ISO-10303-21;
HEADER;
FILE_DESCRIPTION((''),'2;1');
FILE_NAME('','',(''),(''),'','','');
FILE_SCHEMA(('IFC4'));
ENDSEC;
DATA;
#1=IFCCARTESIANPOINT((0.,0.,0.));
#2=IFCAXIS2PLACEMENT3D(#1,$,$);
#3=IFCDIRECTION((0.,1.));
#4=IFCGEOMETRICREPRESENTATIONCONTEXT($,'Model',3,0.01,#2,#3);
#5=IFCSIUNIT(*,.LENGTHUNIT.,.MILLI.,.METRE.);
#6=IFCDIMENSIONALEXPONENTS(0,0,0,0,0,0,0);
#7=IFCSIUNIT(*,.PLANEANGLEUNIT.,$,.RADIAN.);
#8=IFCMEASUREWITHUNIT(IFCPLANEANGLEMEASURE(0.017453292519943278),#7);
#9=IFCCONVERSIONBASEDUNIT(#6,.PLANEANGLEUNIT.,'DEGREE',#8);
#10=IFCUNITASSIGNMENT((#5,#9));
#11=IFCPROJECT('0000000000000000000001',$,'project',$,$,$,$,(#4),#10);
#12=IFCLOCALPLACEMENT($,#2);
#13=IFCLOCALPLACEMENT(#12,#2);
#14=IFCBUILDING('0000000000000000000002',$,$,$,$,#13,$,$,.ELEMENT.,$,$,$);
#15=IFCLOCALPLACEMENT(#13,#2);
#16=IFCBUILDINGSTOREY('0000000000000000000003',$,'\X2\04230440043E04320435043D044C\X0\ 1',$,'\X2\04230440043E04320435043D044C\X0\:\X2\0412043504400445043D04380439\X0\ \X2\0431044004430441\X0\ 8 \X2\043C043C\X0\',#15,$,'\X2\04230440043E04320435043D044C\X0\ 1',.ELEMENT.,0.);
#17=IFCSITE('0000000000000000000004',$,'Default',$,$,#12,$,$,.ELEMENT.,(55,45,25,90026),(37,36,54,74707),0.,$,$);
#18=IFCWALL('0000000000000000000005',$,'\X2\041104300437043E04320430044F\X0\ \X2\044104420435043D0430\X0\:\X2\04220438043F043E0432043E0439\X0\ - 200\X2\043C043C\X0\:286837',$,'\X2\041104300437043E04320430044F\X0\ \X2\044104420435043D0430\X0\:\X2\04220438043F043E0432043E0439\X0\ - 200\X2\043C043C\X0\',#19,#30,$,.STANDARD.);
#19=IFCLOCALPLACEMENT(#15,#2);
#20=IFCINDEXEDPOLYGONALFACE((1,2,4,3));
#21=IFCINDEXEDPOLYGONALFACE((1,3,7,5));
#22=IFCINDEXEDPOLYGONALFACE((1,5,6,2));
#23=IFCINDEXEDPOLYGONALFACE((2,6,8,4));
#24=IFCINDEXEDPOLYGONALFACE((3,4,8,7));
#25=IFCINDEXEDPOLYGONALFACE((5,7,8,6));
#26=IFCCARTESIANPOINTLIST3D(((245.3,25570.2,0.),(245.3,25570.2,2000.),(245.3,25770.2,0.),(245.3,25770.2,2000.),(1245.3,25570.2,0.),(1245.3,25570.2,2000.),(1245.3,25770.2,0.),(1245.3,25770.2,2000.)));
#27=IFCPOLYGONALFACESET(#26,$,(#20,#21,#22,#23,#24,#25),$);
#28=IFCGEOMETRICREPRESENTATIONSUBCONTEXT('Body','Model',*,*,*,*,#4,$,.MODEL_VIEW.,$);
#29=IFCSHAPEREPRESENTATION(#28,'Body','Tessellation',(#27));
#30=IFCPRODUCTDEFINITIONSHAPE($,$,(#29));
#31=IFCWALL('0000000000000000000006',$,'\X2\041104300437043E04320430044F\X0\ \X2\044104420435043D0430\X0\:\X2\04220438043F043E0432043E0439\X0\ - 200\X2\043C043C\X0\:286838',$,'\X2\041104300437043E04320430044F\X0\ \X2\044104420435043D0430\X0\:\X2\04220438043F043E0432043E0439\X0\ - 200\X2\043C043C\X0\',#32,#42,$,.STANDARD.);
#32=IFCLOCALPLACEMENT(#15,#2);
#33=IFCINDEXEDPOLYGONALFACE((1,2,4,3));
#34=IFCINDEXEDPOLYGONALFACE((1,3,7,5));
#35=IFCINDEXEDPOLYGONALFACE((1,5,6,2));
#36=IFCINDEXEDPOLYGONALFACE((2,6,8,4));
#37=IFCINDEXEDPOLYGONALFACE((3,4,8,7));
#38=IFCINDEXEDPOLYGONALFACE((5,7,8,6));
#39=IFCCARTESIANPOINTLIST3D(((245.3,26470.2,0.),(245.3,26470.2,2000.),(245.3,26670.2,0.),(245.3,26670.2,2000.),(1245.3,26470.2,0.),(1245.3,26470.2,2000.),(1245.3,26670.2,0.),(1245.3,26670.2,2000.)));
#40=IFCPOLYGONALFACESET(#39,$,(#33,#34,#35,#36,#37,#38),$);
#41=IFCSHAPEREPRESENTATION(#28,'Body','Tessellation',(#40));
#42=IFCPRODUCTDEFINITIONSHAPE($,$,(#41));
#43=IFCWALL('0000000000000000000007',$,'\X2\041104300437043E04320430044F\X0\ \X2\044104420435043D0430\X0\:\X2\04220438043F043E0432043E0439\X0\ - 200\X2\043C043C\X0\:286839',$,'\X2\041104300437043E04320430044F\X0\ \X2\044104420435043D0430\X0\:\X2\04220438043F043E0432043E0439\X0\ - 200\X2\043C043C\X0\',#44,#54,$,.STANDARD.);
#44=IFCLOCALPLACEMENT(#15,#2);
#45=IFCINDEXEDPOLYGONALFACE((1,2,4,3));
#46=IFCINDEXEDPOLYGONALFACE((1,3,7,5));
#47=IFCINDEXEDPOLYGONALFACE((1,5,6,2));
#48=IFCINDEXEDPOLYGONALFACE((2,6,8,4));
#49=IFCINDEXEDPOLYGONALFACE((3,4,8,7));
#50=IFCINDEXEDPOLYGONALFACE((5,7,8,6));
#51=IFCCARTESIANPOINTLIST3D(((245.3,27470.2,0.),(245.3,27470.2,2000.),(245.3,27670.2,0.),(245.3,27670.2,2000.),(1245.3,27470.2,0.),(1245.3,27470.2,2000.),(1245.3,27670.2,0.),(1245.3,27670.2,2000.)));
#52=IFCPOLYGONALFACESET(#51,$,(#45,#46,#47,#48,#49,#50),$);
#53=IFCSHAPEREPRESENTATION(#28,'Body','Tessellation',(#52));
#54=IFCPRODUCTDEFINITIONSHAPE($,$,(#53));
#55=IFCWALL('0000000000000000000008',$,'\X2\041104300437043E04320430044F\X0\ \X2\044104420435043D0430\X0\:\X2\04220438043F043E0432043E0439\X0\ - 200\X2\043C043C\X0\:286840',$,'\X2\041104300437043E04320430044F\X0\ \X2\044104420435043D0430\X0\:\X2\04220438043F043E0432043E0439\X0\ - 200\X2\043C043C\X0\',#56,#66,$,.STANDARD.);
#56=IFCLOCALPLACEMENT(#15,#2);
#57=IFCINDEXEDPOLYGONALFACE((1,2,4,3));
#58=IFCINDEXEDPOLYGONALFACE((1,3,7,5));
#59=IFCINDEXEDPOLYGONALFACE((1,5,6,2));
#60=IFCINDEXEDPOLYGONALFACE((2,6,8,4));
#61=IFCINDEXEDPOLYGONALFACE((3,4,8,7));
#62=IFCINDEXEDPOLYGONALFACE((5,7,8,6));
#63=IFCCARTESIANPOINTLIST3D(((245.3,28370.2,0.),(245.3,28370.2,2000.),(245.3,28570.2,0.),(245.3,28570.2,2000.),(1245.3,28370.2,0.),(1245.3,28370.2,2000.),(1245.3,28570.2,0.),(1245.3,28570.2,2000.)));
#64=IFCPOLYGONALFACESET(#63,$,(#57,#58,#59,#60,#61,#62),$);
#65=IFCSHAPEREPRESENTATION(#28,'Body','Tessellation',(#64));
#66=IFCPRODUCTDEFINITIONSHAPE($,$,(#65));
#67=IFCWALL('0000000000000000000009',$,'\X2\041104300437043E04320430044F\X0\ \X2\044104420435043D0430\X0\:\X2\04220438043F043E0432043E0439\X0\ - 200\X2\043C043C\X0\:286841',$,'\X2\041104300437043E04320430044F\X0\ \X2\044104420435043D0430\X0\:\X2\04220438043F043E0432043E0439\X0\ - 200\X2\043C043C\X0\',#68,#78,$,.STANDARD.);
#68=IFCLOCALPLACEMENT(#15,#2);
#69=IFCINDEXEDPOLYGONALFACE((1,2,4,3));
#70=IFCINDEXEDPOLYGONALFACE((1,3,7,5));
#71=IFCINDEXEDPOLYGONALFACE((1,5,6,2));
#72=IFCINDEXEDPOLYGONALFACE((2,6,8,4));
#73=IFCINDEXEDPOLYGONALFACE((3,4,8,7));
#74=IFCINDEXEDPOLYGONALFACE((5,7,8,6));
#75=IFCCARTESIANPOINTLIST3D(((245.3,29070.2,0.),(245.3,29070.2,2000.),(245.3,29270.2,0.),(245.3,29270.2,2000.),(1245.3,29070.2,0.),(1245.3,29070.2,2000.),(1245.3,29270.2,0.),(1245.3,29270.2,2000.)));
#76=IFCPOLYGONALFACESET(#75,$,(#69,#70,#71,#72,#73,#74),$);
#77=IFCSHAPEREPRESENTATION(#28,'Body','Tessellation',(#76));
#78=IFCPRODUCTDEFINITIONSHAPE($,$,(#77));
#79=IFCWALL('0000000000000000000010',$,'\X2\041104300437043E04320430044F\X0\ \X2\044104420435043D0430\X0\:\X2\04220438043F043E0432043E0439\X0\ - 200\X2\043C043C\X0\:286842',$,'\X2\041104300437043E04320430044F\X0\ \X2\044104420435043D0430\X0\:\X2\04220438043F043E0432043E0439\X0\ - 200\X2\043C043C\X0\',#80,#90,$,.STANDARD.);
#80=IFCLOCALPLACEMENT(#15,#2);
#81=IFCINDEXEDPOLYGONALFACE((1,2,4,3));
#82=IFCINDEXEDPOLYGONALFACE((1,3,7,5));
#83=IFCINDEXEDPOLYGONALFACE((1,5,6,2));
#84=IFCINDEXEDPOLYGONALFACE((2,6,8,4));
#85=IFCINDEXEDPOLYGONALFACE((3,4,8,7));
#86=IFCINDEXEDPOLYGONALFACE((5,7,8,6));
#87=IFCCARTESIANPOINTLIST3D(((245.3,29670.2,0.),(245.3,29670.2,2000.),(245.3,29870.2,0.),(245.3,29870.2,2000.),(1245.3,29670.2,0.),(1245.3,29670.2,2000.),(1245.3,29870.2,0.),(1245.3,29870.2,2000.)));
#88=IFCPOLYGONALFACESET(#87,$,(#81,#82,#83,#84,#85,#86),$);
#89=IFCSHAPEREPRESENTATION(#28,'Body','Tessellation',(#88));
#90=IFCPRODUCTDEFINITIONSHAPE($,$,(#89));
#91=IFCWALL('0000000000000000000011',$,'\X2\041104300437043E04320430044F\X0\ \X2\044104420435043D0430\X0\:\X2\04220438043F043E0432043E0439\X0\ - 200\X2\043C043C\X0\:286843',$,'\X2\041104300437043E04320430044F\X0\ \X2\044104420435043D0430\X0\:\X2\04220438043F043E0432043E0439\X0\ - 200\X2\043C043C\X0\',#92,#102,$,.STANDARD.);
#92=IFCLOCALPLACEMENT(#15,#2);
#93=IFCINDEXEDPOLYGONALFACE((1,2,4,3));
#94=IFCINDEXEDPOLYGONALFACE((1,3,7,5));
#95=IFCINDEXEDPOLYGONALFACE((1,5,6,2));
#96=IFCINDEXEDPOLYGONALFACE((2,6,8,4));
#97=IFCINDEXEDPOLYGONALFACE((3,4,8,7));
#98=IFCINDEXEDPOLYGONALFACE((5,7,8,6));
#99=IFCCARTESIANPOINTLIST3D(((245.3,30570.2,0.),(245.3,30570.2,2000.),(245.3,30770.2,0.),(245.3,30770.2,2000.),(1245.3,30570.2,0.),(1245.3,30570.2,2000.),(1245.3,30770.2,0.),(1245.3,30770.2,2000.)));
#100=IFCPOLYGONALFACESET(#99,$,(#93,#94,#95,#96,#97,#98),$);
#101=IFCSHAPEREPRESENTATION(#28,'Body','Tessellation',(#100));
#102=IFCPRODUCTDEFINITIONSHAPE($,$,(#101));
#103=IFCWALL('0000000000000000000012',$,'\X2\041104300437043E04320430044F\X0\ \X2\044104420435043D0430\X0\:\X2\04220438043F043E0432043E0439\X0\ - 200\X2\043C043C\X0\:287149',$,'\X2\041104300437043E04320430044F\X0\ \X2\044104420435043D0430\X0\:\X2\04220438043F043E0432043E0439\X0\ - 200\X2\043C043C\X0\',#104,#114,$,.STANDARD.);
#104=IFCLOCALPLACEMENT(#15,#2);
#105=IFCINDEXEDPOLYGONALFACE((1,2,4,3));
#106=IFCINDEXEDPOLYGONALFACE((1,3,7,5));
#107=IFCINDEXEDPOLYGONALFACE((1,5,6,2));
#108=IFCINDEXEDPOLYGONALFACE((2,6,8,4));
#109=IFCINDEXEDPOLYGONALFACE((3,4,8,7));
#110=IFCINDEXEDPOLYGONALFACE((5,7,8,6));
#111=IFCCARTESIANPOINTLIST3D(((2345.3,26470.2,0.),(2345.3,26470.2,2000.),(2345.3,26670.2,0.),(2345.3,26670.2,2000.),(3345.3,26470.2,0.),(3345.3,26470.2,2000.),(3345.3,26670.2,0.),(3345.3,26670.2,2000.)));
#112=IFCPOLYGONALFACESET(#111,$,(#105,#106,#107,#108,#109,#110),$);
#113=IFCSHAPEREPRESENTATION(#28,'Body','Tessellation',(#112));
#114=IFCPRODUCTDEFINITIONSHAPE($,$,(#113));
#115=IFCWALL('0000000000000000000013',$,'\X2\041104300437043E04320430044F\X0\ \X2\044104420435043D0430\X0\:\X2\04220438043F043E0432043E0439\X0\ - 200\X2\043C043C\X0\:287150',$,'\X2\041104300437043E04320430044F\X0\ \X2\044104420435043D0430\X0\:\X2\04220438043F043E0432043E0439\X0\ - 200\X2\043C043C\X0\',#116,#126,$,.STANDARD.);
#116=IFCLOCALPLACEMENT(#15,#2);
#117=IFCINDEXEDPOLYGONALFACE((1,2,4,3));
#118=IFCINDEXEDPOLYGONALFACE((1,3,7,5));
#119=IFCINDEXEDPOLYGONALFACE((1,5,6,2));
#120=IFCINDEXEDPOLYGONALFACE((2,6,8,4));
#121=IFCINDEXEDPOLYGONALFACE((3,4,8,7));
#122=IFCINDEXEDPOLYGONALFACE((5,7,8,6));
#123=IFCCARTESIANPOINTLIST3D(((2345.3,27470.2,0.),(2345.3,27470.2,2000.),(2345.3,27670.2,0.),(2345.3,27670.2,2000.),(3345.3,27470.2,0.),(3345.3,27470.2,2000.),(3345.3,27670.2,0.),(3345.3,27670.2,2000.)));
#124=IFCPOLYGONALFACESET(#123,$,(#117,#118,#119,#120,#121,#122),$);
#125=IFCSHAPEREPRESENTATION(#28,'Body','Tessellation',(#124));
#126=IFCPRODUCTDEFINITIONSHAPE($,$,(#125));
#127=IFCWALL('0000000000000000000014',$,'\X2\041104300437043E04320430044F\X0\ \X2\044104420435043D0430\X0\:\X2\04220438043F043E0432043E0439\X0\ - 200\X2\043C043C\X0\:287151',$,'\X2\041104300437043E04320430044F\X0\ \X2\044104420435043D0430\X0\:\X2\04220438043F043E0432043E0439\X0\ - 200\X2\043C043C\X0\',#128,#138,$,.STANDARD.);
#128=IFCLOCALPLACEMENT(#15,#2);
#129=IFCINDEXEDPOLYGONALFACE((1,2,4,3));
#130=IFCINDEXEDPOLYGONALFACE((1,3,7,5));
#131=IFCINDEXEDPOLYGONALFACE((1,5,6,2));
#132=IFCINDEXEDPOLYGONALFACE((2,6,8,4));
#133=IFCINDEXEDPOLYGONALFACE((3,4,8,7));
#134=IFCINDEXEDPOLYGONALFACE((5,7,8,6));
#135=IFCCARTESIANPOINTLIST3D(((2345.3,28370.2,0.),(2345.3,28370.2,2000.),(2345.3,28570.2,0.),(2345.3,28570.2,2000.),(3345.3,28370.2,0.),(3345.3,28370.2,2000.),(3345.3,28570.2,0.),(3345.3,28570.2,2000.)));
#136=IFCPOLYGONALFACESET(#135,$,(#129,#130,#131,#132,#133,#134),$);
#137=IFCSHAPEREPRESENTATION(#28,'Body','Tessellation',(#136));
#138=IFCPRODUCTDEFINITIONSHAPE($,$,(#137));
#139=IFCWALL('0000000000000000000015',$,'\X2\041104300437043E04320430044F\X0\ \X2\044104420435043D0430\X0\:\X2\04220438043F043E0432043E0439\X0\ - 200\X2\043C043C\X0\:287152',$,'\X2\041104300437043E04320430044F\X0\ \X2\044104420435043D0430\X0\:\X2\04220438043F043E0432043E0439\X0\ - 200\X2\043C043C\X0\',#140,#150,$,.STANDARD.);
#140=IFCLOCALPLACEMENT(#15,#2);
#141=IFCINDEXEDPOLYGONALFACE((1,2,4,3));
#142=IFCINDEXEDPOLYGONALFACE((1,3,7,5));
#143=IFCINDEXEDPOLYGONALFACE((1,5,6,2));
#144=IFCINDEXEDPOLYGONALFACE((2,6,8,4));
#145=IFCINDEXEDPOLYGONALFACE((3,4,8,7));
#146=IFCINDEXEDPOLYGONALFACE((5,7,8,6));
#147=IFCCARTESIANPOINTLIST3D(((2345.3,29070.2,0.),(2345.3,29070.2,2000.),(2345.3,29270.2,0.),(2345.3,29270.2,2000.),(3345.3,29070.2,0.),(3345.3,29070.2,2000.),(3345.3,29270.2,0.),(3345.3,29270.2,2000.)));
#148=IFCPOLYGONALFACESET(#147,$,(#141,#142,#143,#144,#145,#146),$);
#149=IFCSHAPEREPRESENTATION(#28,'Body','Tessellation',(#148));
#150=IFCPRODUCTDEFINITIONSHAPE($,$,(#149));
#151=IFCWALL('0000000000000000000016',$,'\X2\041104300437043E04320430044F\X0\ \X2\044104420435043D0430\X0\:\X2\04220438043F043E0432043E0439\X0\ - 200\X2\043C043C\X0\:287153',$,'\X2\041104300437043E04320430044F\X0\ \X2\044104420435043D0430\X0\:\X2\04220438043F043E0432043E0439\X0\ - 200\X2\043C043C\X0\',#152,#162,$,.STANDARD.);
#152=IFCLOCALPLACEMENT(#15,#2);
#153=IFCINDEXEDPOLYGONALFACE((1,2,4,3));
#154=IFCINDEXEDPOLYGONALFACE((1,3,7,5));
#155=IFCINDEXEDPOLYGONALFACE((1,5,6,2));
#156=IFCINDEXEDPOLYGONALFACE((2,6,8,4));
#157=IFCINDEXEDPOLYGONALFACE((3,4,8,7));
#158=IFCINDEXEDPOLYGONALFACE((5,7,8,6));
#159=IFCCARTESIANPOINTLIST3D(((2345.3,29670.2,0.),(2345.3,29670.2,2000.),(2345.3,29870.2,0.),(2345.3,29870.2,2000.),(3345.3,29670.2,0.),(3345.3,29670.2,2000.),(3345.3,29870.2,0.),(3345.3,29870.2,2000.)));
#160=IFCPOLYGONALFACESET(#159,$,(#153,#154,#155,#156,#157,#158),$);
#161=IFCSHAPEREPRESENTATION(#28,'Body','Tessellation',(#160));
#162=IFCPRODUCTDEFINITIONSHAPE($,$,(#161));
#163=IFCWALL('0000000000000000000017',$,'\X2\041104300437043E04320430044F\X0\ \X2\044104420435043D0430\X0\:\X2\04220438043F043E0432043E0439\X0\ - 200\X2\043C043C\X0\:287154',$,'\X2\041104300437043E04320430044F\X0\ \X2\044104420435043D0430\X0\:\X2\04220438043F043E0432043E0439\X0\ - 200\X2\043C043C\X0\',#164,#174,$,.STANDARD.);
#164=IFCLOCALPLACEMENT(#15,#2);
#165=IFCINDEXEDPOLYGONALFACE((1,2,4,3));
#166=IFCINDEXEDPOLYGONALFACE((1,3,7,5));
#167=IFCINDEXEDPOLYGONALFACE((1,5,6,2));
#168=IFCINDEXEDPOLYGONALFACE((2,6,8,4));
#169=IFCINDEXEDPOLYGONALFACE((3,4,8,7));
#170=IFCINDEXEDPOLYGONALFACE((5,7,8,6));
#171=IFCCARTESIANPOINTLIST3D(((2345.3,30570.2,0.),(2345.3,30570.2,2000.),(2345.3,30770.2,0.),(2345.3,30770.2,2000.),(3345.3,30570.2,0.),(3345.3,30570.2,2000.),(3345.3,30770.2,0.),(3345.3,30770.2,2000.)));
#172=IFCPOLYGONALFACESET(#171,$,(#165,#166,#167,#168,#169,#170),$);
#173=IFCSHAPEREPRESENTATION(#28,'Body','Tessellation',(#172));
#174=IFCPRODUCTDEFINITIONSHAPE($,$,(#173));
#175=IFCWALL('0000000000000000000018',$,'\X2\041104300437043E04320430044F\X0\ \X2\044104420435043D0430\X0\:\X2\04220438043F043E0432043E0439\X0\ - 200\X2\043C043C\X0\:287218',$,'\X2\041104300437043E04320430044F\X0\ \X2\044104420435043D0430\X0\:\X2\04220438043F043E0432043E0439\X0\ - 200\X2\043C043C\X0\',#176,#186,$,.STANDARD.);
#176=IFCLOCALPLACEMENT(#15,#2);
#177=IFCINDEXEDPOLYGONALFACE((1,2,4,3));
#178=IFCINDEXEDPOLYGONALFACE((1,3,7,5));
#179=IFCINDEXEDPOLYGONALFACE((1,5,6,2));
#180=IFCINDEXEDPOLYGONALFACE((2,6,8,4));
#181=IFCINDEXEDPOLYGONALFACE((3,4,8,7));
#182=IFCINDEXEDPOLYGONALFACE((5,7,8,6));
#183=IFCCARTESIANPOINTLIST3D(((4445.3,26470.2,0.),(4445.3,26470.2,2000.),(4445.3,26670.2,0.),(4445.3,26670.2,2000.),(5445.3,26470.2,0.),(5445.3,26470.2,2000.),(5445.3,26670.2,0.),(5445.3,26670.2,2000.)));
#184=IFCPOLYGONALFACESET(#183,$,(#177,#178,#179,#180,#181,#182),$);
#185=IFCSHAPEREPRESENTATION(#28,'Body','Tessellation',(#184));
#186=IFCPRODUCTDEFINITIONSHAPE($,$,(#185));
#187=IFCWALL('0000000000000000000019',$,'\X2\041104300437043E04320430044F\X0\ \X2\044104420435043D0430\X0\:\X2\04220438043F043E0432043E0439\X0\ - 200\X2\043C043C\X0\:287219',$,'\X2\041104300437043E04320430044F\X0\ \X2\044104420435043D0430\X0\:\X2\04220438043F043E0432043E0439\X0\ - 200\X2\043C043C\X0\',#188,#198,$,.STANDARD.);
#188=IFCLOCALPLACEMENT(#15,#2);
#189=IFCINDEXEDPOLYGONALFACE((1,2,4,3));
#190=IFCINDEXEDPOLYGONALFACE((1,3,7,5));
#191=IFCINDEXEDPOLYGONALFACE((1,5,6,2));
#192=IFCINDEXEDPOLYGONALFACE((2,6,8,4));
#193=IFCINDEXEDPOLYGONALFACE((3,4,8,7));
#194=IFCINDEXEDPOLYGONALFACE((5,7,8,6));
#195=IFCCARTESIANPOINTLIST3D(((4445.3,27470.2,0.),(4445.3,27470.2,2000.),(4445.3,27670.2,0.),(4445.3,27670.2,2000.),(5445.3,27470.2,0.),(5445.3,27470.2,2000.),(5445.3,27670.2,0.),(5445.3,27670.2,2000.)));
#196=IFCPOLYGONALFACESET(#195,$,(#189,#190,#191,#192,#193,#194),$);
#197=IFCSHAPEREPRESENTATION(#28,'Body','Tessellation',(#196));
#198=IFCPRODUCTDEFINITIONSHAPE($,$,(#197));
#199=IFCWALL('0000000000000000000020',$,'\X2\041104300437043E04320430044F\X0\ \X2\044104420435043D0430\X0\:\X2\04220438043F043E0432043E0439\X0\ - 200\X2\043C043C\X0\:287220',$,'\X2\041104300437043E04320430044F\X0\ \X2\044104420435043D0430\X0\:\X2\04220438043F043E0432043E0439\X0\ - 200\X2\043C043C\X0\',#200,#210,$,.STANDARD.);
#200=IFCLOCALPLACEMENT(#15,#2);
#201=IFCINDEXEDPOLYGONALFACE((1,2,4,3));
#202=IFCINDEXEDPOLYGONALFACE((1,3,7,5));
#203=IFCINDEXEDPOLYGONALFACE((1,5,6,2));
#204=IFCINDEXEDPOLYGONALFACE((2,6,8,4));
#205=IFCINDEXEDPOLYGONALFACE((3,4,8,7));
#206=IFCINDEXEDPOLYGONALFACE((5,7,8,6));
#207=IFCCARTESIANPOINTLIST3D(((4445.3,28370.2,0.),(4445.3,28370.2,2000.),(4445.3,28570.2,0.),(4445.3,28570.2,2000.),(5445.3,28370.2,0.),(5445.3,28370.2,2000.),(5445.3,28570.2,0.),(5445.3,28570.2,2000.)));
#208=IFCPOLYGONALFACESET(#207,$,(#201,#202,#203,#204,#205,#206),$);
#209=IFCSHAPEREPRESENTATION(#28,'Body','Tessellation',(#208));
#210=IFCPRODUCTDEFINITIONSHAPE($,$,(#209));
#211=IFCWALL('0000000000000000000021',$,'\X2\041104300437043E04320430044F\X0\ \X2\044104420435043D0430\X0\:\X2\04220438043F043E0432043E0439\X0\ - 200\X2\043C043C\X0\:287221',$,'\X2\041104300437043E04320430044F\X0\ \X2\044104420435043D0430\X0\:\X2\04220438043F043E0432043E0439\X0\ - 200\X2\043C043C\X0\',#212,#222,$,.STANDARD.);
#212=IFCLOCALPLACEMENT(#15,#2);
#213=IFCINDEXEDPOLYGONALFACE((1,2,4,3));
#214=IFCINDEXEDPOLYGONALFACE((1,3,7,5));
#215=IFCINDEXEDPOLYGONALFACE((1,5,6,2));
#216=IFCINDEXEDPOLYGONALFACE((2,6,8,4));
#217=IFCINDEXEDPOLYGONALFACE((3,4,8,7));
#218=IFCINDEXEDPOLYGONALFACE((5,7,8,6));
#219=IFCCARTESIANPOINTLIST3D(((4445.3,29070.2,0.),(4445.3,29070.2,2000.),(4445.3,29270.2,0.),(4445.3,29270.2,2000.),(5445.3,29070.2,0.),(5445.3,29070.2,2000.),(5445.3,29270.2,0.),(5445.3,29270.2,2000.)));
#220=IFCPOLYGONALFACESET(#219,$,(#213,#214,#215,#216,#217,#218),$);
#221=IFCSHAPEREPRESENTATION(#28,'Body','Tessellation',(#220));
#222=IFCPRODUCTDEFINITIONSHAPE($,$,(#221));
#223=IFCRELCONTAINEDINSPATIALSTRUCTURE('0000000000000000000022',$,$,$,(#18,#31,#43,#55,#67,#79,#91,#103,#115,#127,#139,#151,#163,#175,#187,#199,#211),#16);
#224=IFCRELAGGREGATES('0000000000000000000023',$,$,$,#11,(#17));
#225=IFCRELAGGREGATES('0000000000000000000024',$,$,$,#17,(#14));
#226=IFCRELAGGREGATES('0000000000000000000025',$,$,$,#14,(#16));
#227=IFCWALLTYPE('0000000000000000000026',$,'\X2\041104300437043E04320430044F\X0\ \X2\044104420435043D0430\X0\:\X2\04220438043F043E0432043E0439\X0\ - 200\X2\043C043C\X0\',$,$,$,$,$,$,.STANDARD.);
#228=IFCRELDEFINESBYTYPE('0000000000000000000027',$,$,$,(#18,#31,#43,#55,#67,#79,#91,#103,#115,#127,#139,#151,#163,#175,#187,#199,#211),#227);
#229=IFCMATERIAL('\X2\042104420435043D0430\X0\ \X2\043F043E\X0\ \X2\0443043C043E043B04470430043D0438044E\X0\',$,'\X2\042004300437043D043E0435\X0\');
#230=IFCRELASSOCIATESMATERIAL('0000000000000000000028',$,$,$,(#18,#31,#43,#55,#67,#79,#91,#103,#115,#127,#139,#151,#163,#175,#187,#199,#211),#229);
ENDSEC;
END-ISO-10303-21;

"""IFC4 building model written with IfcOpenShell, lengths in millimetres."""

from ifc_helpers import new_model, entity, si_unit, converted_unit, direction, frame, origin, place, context, subcontext, project, spatial, indexed_curve, outline, extrude, material, type_object, element, save


model = new_model("IFC4")

# Units and contexts
model_context = context("Model", 3, precision=0.01, world=origin(), true_north=direction((0.0, 1.0)))
body_context = subcontext(model_context, "Body", "Model", "MODEL_VIEW")
ifc_project = project(units=[si_unit("LENGTHUNIT", "METRE", prefix="MILLI"), converted_unit("PLANEANGLEUNIT", "DEGREE", entity("IfcPlaneAngleMeasure", 0.017453292519943278), si_unit("PLANEANGLEUNIT", "RADIAN"), dimensions=[0, 0, 0, 0, 0, 0, 0])], contexts=[model_context])

# Site, building, storey
site_placement = place(None, origin())
site = spatial("IfcSite", under=ifc_project, at=site_placement, Name="Default", CompositionType="ELEMENT", RefLatitude=(55, 45, 25, 90026), RefLongitude=(37, 36, 54, 74707), RefElevation=0.0)
building_placement = place(site_placement, origin())
building = spatial("IfcBuilding", under=site, at=building_placement, CompositionType="ELEMENT")
storey_placement = place(building_placement, origin())
storey = spatial("IfcBuildingStorey", under=building, at=storey_placement, Name="Уровень 1", ObjectType="Уровень:Верхний брус 8 мм", LongName="Уровень 1", CompositionType="ELEMENT", Elevation=0.0)

# Walls
ifc_material = material(Name="Стена по умолчанию", Category="Разное")
wall_type = type_object("IfcWallType", Name="Базовая стена:Типовой - 200мм", PredefinedType="STANDARD")
for number, where, name in (
    (1, (245.3, 25670.2, 0.0), "Базовая стена:Типовой - 200мм:286837"),
    (2, (245.3, 26570.2, 0.0), "Базовая стена:Типовой - 200мм:286838"),
    (3, (245.3, 27570.2, 0.0), "Базовая стена:Типовой - 200мм:286839"),
):
    element("IfcWall", number, at=place(storey_placement, frame(where)), inside=storey, type_object=wall_type, material=ifc_material, Name=name, ObjectType="Базовая стена:Типовой - 200мм", PredefinedType="STANDARD", context=body_context, shape_type="SweptSolid", body=[
        extrude(outline(indexed_curve([(1000.0, 100.0), (0.0, 100.0), (0.0, -100.0), (1000.0, -100.0), (1000.0, 100.0)], self_intersect=False)), origin(), (0.0, 0.0, 1.0), 2000.0),
    ])
for number, where, name in (
    (4, (245.3, 28470.2, 0.0), "Базовая стена:Типовой - 200мм:286840"),
    (5, (245.3, 29170.2, 0.0), "Базовая стена:Типовой - 200мм:286841"),
):
    element("IfcWall", number, at=place(storey_placement, frame(where)), inside=storey, type_object=wall_type, material=ifc_material, Name=name, ObjectType="Базовая стена:Типовой - 200мм", PredefinedType="STANDARD", context=body_context, shape_type="SweptSolid", body=[
        extrude(outline(indexed_curve([(1000.0, 100.0), (0.0, 100.0), (0.0, -100.0), (1000.0, -100.0), (1000.0, 100.0)], self_intersect=False)), origin(), (0.0, 0.0, 1.0), 2000.0),
    ])
for number, where, name in (
    (6, (245.3, 29770.2, 0.0), "Базовая стена:Типовой - 200мм:286842"),
    (7, (245.3, 30670.2, 0.0), "Базовая стена:Типовой - 200мм:286843"),
):
    element("IfcWall", number, at=place(storey_placement, frame(where)), inside=storey, type_object=wall_type, material=ifc_material, Name=name, ObjectType="Базовая стена:Типовой - 200мм", PredefinedType="STANDARD", context=body_context, shape_type="SweptSolid", body=[
        extrude(outline(indexed_curve([(1000.0, 100.0), (0.0, 100.0), (0.0, -100.0), (1000.0, -100.0), (1000.0, 100.0)], self_intersect=False)), origin(), (0.0, 0.0, 1.0), 2000.0),
    ])
for number, where, name in (
    (8, (2345.3, 26570.2, 0.0), "Базовая стена:Типовой - 200мм:287149"),
    (9, (2345.3, 27570.2, 0.0), "Базовая стена:Типовой - 200мм:287150"),
):
    element("IfcWall", number, at=place(storey_placement, frame(where)), inside=storey, type_object=wall_type, material=ifc_material, Name=name, ObjectType="Базовая стена:Типовой - 200мм", PredefinedType="STANDARD", context=body_context, shape_type="SweptSolid", body=[
        extrude(outline(indexed_curve([(1000.0, 100.0), (0.0, 100.0), (0.0, -100.0), (1000.0, -100.0), (1000.0, 100.0)], self_intersect=False)), origin(), (0.0, 0.0, 1.0), 2000.0),
    ])
for number, where, name in (
    (10, (2345.3, 28470.2, 0.0), "Базовая стена:Типовой - 200мм:287151"),
    (11, (2345.3, 29170.2, 0.0), "Базовая стена:Типовой - 200мм:287152"),
):
    element("IfcWall", number, at=place(storey_placement, frame(where)), inside=storey, type_object=wall_type, material=ifc_material, Name=name, ObjectType="Базовая стена:Типовой - 200мм", PredefinedType="STANDARD", context=body_context, shape_type="SweptSolid", body=[
        extrude(outline(indexed_curve([(1000.0, 100.0), (0.0, 100.0), (0.0, -100.0), (1000.0, -100.0), (1000.0, 100.0)], self_intersect=False)), origin(), (0.0, 0.0, 1.0), 2000.0),
    ])
for number, where, name in (
    (12, (2345.3, 29770.2, 0.0), "Базовая стена:Типовой - 200мм:287153"),
    (13, (2345.3, 30670.2, 0.0), "Базовая стена:Типовой - 200мм:287154"),
):
    element("IfcWall", number, at=place(storey_placement, frame(where)), inside=storey, type_object=wall_type, material=ifc_material, Name=name, ObjectType="Базовая стена:Типовой - 200мм", PredefinedType="STANDARD", context=body_context, shape_type="SweptSolid", body=[
        extrude(outline(indexed_curve([(1000.0, 100.0), (0.0, 100.0), (0.0, -100.0), (1000.0, -100.0), (1000.0, 100.0)], self_intersect=False)), origin(), (0.0, 0.0, 1.0), 2000.0),
    ])
for number, where, name in (
    (14, (4445.3, 26570.2, 0.0), "Базовая стена:Типовой - 200мм:287218"),
    (15, (4445.3, 27570.2, 0.0), "Базовая стена:Типовой - 200мм:287219"),
):
    element("IfcWall", number, at=place(storey_placement, frame(where)), inside=storey, type_object=wall_type, material=ifc_material, Name=name, ObjectType="Базовая стена:Типовой - 200мм", PredefinedType="STANDARD", context=body_context, shape_type="SweptSolid", body=[
        extrude(outline(indexed_curve([(1000.0, 100.0), (0.0, 100.0), (0.0, -100.0), (1000.0, -100.0), (1000.0, 100.0)], self_intersect=False)), origin(), (0.0, 0.0, 1.0), 2000.0),
    ])
for number, where, name in (
    (16, (4445.3, 28470.2, 0.0), "Базовая стена:Типовой - 200мм:287220"),
    (17, (4445.3, 29170.2, 0.0), "Базовая стена:Типовой - 200мм:287221"),
):
    element("IfcWall", number, at=place(storey_placement, frame(where)), inside=storey, type_object=wall_type, material=ifc_material, Name=name, ObjectType="Базовая стена:Типовой - 200мм", PredefinedType="STANDARD", context=body_context, shape_type="SweptSolid", body=[
        extrude(outline(indexed_curve([(1000.0, 100.0), (0.0, 100.0), (0.0, -100.0), (1000.0, -100.0), (1000.0, 100.0)], self_intersect=False)), origin(), (0.0, 0.0, 1.0), 2000.0),
    ])

save(model, "model.ifc")
